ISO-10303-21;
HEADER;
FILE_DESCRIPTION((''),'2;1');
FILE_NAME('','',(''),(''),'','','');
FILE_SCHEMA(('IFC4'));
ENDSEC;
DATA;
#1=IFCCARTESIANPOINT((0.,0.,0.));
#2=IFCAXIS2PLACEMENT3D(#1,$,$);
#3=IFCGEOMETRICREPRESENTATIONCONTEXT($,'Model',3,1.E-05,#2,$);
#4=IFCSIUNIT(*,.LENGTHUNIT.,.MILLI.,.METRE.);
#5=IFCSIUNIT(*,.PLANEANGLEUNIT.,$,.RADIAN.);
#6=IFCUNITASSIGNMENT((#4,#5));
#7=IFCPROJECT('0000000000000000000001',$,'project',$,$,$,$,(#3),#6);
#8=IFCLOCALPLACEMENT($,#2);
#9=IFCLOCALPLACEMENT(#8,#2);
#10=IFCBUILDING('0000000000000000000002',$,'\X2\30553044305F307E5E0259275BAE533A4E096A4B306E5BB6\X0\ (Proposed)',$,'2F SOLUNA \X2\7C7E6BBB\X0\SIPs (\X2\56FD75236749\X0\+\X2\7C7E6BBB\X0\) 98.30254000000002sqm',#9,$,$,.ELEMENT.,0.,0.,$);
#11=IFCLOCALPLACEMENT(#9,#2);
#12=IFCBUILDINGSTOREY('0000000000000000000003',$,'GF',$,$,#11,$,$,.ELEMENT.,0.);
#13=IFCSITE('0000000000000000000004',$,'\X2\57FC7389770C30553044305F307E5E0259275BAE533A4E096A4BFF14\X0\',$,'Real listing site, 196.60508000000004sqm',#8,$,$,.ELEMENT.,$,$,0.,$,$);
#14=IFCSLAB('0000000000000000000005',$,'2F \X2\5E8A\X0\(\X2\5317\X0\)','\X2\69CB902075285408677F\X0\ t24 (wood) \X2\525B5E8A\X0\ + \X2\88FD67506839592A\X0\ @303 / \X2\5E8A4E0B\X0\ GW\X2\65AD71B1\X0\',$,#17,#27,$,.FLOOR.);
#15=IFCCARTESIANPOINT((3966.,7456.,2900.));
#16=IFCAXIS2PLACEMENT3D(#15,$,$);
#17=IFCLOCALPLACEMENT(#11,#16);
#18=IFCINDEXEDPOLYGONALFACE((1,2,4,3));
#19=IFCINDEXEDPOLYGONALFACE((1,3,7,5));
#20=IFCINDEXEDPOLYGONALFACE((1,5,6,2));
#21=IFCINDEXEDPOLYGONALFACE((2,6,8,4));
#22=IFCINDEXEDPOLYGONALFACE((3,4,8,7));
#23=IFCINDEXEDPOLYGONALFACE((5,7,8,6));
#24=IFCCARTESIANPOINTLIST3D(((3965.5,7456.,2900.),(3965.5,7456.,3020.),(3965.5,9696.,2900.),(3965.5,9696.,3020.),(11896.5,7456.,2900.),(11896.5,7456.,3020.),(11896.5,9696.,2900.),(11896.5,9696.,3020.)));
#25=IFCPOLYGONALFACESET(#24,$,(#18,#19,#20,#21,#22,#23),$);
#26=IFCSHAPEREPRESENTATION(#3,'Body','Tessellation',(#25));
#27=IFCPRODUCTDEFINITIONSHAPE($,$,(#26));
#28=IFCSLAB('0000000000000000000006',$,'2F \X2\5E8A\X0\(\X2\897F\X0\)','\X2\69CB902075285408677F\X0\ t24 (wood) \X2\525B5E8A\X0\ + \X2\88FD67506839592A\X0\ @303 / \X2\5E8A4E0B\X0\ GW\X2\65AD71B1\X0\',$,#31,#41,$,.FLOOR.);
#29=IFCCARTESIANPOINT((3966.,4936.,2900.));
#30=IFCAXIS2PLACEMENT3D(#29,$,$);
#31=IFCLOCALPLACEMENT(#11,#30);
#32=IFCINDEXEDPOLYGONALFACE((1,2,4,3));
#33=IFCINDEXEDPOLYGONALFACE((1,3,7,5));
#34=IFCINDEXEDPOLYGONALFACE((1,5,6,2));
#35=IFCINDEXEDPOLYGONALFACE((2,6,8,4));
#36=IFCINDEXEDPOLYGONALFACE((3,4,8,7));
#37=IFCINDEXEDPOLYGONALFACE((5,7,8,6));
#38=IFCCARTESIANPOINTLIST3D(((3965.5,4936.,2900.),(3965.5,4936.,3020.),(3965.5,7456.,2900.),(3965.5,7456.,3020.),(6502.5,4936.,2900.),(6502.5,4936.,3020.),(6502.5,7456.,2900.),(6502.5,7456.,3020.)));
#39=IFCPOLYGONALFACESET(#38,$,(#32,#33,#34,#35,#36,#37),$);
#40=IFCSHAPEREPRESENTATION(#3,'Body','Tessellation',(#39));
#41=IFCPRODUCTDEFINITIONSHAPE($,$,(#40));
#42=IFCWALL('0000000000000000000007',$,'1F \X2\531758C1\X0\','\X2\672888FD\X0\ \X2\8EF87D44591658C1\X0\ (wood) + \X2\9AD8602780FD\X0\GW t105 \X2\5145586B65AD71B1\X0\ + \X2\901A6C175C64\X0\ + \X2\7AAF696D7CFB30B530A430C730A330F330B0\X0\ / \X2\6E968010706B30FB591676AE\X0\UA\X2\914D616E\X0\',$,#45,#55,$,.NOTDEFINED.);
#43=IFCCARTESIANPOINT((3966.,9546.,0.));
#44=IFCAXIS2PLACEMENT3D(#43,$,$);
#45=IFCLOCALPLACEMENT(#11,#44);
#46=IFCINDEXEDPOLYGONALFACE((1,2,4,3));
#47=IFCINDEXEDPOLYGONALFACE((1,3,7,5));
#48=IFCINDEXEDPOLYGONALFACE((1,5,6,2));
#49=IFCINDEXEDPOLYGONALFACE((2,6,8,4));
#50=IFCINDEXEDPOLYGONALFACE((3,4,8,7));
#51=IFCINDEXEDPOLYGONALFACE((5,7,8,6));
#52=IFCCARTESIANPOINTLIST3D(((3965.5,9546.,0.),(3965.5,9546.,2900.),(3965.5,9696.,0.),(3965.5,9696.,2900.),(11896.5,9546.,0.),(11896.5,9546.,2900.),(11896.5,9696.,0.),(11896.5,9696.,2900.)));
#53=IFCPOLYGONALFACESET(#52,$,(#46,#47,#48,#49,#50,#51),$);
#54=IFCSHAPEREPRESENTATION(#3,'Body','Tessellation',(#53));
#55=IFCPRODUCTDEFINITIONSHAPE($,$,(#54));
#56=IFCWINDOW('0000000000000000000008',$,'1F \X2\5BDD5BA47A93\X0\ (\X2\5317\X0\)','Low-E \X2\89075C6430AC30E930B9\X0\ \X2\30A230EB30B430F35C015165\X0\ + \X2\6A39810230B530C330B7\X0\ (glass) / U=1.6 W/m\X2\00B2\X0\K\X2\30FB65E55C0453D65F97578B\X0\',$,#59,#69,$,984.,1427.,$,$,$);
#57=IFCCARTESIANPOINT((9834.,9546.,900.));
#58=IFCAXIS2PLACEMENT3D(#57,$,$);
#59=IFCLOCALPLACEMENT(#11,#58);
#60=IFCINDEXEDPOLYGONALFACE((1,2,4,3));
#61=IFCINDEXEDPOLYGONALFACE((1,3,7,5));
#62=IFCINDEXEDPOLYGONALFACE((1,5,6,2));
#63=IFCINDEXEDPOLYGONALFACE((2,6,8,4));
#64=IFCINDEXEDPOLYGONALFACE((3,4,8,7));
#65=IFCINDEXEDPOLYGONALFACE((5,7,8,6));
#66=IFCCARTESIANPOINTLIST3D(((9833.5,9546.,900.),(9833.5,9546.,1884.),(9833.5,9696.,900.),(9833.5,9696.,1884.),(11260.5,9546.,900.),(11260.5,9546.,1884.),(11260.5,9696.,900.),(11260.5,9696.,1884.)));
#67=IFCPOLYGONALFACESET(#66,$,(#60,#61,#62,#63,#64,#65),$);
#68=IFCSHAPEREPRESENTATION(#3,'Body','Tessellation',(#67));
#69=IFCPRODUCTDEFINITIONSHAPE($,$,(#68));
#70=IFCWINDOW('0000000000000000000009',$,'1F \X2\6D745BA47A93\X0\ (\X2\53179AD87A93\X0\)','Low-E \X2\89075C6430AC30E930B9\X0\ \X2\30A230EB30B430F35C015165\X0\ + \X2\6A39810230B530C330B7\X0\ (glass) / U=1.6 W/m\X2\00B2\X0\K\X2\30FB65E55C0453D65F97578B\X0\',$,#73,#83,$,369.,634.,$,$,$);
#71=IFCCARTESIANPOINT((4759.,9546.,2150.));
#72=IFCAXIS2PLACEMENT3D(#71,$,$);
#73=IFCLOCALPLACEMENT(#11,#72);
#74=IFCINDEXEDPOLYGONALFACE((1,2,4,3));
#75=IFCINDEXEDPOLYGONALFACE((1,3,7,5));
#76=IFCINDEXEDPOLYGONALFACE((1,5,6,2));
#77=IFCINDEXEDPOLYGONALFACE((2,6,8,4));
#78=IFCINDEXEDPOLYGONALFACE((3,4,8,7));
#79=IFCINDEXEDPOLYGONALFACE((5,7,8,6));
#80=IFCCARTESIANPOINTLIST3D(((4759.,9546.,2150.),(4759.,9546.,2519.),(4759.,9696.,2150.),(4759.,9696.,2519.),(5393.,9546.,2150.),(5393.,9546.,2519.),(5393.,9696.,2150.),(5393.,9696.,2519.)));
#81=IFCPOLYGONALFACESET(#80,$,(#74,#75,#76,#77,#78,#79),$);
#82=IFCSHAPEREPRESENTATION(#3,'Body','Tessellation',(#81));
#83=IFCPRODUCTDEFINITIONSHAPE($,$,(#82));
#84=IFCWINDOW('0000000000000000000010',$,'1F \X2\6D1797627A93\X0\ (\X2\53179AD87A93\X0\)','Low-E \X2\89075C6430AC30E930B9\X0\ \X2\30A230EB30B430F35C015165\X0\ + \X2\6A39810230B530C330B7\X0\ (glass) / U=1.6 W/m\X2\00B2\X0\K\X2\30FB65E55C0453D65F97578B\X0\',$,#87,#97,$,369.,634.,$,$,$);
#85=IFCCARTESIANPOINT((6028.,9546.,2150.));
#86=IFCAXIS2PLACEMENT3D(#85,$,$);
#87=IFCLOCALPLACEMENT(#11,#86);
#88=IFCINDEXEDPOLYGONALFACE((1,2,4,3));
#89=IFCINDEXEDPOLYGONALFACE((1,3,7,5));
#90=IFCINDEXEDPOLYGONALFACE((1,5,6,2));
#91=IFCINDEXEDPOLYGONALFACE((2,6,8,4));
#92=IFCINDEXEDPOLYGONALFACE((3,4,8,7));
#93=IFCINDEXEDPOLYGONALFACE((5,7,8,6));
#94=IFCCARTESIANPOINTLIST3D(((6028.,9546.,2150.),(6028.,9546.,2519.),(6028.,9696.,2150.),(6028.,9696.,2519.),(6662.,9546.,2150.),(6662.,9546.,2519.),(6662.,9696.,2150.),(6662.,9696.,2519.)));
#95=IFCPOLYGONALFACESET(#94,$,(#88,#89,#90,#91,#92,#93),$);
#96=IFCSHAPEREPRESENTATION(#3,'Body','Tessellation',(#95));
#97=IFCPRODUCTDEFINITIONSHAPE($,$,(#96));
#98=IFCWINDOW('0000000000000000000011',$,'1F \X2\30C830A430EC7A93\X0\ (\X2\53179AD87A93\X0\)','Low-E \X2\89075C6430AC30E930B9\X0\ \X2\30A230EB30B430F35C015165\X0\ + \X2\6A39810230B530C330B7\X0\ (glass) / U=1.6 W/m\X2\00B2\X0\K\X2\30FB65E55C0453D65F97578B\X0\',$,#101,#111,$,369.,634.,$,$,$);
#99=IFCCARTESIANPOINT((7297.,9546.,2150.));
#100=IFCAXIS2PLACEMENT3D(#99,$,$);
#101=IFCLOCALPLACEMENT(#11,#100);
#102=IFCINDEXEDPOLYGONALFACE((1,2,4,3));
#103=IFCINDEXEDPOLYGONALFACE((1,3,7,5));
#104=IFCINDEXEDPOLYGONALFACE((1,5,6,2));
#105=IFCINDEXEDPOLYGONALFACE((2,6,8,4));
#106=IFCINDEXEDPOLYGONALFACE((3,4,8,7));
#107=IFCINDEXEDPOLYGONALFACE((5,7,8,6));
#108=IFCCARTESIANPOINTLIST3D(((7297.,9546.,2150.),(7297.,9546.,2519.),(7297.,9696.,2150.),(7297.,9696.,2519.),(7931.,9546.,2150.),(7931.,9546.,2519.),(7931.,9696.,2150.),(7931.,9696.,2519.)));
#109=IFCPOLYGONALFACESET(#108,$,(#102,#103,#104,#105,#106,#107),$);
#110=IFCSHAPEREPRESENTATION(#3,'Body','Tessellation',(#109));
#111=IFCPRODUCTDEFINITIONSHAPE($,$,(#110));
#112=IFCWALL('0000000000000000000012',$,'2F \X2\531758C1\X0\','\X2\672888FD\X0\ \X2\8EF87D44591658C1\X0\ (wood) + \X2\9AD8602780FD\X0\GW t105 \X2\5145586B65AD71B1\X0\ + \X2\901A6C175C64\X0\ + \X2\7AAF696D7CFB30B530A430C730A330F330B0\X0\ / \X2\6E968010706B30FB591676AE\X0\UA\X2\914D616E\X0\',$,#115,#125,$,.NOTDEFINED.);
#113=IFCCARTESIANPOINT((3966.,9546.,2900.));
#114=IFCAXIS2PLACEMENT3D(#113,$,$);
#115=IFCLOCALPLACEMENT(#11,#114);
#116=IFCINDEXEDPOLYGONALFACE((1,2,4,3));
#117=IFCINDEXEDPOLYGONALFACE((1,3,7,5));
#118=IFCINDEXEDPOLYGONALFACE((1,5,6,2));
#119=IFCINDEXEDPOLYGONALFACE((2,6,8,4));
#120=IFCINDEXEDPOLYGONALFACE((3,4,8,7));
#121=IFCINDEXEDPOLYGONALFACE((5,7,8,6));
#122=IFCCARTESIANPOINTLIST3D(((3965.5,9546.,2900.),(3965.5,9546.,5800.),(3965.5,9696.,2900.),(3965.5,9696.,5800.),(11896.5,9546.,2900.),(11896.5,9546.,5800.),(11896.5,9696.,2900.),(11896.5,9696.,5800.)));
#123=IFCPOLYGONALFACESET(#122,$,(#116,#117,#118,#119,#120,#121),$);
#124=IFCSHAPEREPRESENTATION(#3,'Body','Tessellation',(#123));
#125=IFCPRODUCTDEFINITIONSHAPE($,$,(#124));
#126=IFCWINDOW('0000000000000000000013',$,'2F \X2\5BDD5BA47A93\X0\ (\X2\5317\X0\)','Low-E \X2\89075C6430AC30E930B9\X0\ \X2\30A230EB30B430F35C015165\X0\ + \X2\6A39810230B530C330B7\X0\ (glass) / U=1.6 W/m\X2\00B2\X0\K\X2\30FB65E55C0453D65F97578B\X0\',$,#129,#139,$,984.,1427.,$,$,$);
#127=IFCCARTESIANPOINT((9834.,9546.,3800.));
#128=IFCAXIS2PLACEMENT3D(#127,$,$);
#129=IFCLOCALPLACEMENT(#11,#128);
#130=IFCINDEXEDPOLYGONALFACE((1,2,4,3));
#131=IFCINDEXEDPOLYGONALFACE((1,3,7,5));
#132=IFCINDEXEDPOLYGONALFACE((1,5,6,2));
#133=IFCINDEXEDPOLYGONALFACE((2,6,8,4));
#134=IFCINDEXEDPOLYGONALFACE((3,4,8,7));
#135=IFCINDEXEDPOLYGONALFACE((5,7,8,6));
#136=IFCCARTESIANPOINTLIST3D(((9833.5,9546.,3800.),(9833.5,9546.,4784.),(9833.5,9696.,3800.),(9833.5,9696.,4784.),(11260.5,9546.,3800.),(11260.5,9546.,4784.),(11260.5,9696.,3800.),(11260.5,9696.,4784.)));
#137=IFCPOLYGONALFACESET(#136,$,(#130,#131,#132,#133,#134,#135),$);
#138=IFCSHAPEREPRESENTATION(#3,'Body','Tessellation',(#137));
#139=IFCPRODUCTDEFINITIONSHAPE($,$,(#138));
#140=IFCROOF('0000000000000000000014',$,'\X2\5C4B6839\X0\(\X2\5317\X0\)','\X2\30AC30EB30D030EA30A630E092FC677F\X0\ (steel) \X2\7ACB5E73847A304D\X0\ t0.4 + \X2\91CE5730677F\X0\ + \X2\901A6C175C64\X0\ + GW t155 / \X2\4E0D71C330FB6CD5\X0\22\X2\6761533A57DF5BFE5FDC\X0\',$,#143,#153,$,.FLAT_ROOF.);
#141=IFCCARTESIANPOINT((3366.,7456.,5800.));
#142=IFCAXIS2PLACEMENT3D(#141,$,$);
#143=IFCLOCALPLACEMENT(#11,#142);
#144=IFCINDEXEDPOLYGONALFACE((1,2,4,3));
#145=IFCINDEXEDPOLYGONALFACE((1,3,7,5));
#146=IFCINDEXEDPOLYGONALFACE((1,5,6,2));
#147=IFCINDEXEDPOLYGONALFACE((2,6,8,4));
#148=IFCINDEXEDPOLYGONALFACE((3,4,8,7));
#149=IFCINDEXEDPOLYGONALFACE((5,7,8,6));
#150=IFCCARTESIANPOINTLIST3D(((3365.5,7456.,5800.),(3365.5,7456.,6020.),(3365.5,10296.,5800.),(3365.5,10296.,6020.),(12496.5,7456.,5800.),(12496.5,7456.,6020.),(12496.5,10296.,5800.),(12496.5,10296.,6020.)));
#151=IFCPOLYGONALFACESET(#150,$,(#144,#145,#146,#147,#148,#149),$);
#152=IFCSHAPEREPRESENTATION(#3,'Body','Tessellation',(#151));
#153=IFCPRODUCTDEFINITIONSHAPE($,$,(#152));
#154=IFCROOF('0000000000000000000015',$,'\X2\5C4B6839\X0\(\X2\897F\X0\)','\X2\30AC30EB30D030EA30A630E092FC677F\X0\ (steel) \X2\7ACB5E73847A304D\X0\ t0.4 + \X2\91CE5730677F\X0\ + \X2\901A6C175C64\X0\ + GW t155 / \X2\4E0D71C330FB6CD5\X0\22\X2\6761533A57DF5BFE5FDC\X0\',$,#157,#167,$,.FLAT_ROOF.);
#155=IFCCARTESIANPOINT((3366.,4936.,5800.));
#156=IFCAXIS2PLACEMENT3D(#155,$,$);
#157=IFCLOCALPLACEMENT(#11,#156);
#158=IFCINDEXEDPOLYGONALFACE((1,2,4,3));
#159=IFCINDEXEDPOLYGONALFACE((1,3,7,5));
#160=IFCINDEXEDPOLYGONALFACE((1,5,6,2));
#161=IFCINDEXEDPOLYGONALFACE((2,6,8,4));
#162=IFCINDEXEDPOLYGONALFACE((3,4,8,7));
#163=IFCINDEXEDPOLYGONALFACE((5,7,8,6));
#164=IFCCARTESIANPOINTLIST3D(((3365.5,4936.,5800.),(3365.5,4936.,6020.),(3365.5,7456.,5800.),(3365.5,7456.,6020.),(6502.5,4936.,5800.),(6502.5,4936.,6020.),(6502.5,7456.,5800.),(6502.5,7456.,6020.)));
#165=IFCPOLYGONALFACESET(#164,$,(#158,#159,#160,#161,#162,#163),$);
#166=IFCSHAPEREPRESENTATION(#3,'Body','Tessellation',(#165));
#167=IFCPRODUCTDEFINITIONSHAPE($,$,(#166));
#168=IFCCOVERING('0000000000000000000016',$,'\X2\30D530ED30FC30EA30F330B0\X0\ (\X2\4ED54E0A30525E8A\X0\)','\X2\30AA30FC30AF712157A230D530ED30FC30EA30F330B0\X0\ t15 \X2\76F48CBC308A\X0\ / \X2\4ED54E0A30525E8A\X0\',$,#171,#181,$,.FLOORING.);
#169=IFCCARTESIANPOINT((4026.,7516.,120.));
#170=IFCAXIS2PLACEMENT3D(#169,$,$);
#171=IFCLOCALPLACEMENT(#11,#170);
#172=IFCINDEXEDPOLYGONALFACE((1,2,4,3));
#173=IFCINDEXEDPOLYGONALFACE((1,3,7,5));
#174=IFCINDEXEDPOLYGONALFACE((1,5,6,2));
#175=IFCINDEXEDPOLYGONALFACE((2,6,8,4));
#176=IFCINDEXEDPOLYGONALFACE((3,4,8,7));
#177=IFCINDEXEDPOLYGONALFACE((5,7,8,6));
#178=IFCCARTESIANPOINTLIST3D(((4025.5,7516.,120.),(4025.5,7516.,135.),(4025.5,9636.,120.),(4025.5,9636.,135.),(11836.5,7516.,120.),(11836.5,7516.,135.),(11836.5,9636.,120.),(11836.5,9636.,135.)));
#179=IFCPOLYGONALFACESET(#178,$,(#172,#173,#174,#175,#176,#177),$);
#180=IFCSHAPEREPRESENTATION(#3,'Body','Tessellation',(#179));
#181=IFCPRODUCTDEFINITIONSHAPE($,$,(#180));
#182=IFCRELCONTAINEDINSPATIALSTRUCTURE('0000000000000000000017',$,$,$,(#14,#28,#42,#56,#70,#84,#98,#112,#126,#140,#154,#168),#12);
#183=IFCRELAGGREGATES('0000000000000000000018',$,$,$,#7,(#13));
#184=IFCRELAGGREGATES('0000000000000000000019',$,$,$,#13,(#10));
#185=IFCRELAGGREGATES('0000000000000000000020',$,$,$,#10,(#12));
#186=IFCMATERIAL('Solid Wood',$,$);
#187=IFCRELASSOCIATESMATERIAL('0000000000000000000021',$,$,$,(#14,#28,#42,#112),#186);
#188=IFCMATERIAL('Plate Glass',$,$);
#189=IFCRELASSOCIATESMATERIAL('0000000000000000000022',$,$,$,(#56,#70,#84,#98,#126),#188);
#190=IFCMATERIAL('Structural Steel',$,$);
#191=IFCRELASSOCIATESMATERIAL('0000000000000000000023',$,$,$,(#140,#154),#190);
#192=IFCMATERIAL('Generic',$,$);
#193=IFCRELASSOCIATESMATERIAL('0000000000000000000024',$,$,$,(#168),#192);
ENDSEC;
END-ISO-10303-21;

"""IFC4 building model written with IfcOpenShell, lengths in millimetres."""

from ifc_helpers import new_model, si_unit, frame, frame_2d, origin, place, context, project, spatial, rectangle, extrude, material, element, fill, save


model = new_model("IFC4")

# Units and contexts
model_context = context("Model", 3, precision=1e-05, world=origin())
ifc_project = project(units=[si_unit("LENGTHUNIT", "METRE", prefix="MILLI"), si_unit("PLANEANGLEUNIT", "RADIAN")], contexts=[model_context])

# Site, building, storey
site_placement = place(None, origin())
site = spatial("IfcSite", under=ifc_project, at=site_placement, Name="埼玉県さいたま市大宮区三橋４", ObjectType="Real listing site, 196.60508000000004sqm", CompositionType="ELEMENT", RefElevation=0.0)
building_placement = place(site_placement, origin())
building = spatial("IfcBuilding", under=site, at=building_placement, Name="さいたま市大宮区三橋の家 (Proposed)", ObjectType="2F SOLUNA 籾殻SIPs (国産杉+籾殻) 98.30254000000002sqm", CompositionType="ELEMENT", ElevationOfRefHeight=0.0, ElevationOfTerrain=0.0)
storey_placement = place(building_placement, origin())
storey = spatial("IfcBuildingStorey", under=building, at=storey_placement, Name="GF", CompositionType="ELEMENT", Elevation=0.0)

# Slabs
ifc_material_1 = material(Name="Solid Wood")
slab_1_placement = place(storey_placement, frame((3966.0, 7456.0, 2900.0)))
element("IfcSlab", 1, at=slab_1_placement, inside=storey, material=ifc_material_1, Name="2F 床(北)", Description="構造用合板 t24 (wood) 剛床 + 製材根太 @303 / 床下 GW断熱", PredefinedType="FLOOR", context=model_context, shape_type="SweptSolid", body=[
    extrude(rectangle(XDim=7931.0, YDim=2240.0, at=frame_2d((3965.0, 1120.0))), frame((3966.0, 7456.0, 2900.0)), (0.0, 0.0, 1.0), 120.0),
])
slab_2_placement = place(storey_placement, frame((3966.0, 4936.0, 2900.0)))
element("IfcSlab", 2, at=slab_2_placement, inside=storey, material=ifc_material_1, Name="2F 床(西)", Description="構造用合板 t24 (wood) 剛床 + 製材根太 @303 / 床下 GW断熱", PredefinedType="FLOOR", context=model_context, shape_type="SweptSolid", body=[
    extrude(rectangle(XDim=2537.0, YDim=2520.0, at=frame_2d((1268.0, 1260.0))), frame((3966.0, 4936.0, 2900.0)), (0.0, 0.0, 1.0), 120.0),
])

# Wall, openings, windows
wall_1_placement = place(storey_placement, frame((3966.0, 9546.0, 0.0)))
wall_1 = element("IfcWall", 3, at=wall_1_placement, inside=storey, material=ifc_material_1, Name="1F 北壁", Description="木製 軸組外壁 (wood) + 高性能GW t105 充填断熱 + 通気層 + 窯業系サイディング / 準耐火・外皮UA配慮", PredefinedType="NOTDEFINED", context=model_context, shape_type="SweptSolid", body=[
    extrude(rectangle(XDim=7931.0, YDim=150.0, at=frame_2d((3965.0, 75.0))), frame((3966.0, 9546.0, 0.0)), (0.0, 0.0, 1.0), 2900.0),
])
opening_1_placement = place(storey_placement, frame((9834.0, 9546.0, 900.0)))
opening_1 = element("IfcOpeningElement", 4, at=opening_1_placement, cuts=wall_1, PredefinedType="NOTDEFINED", context=model_context, shape_type="SweptSolid", body=[
    extrude(rectangle(XDim=1427.0, YDim=150.0, at=frame_2d((713.0, 75.0))), frame((9834.0, 9546.0, 900.0)), (0.0, 0.0, 1.0), 984.0),
])
opening_2_placement = place(storey_placement, frame((4759.0, 9546.0, 2150.0)))
opening_2 = element("IfcOpeningElement", 5, at=opening_2_placement, cuts=wall_1, PredefinedType="NOTDEFINED", context=model_context, shape_type="SweptSolid", body=[
    extrude(rectangle(XDim=634.0, YDim=150.0, at=frame_2d((317.0, 75.0))), frame((4759.0, 9546.0, 2150.0)), (0.0, 0.0, 1.0), 369.0),
])
opening_3_placement = place(storey_placement, frame((6028.0, 9546.0, 2150.0)))
opening_3 = element("IfcOpeningElement", 6, at=opening_3_placement, cuts=wall_1, PredefinedType="NOTDEFINED", context=model_context, shape_type="SweptSolid", body=[
    extrude(rectangle(XDim=634.0, YDim=150.0, at=frame_2d((317.0, 75.0))), frame((6028.0, 9546.0, 2150.0)), (0.0, 0.0, 1.0), 369.0),
])
opening_4_placement = place(storey_placement, frame((7297.0, 9546.0, 2150.0)))
opening_4 = element("IfcOpeningElement", 7, at=opening_4_placement, cuts=wall_1, PredefinedType="NOTDEFINED", context=model_context, shape_type="SweptSolid", body=[
    extrude(rectangle(XDim=634.0, YDim=150.0, at=frame_2d((317.0, 75.0))), frame((7297.0, 9546.0, 2150.0)), (0.0, 0.0, 1.0), 369.0),
])
ifc_material_2 = material(Name="Plate Glass")
window_1_placement = place(storey_placement, frame((9834.0, 9546.0, 900.0)))
window_1 = element("IfcWindow", 8, at=window_1_placement, inside=storey, material=ifc_material_2, Name="1F 寝室窓 (北)", Description="Low-E 複層ガラス アルゴン封入 + 樹脂サッシ (glass) / U=1.6 W/m²K・日射取得型", OverallHeight=984.0, OverallWidth=1427.0, context=model_context, shape_type="SweptSolid", body=[
    extrude(rectangle(XDim=1427.0, YDim=150.0, at=frame_2d((713.0, 75.0))), frame((9834.0, 9546.0, 900.0)), (0.0, 0.0, 1.0), 984.0),
])
fill(opening_1, window_1)
window_2_placement = place(storey_placement, frame((4759.0, 9546.0, 2150.0)))
window_2 = element("IfcWindow", 9, at=window_2_placement, inside=storey, material=ifc_material_2, Name="1F 浴室窓 (北高窓)", Description="Low-E 複層ガラス アルゴン封入 + 樹脂サッシ (glass) / U=1.6 W/m²K・日射取得型", OverallHeight=369.0, OverallWidth=634.0, context=model_context, shape_type="SweptSolid", body=[
    extrude(rectangle(XDim=634.0, YDim=150.0, at=frame_2d((317.0, 75.0))), frame((4759.0, 9546.0, 2150.0)), (0.0, 0.0, 1.0), 369.0),
])
fill(opening_2, window_2)
window_3_placement = place(storey_placement, frame((6028.0, 9546.0, 2150.0)))
window_3 = element("IfcWindow", 10, at=window_3_placement, inside=storey, material=ifc_material_2, Name="1F 洗面窓 (北高窓)", Description="Low-E 複層ガラス アルゴン封入 + 樹脂サッシ (glass) / U=1.6 W/m²K・日射取得型", OverallHeight=369.0, OverallWidth=634.0, context=model_context, shape_type="SweptSolid", body=[
    extrude(rectangle(XDim=634.0, YDim=150.0, at=frame_2d((317.0, 75.0))), frame((6028.0, 9546.0, 2150.0)), (0.0, 0.0, 1.0), 369.0),
])
fill(opening_3, window_3)
window_4_placement = place(storey_placement, frame((7297.0, 9546.0, 2150.0)))
window_4 = element("IfcWindow", 11, at=window_4_placement, inside=storey, material=ifc_material_2, Name="1F トイレ窓 (北高窓)", Description="Low-E 複層ガラス アルゴン封入 + 樹脂サッシ (glass) / U=1.6 W/m²K・日射取得型", OverallHeight=369.0, OverallWidth=634.0, context=model_context, shape_type="SweptSolid", body=[
    extrude(rectangle(XDim=634.0, YDim=150.0, at=frame_2d((317.0, 75.0))), frame((7297.0, 9546.0, 2150.0)), (0.0, 0.0, 1.0), 369.0),
])
fill(opening_4, window_4)

# Wall, opening, window
wall_2_placement = place(storey_placement, frame((3966.0, 9546.0, 2900.0)))
wall_2 = element("IfcWall", 12, at=wall_2_placement, inside=storey, material=ifc_material_1, Name="2F 北壁", Description="木製 軸組外壁 (wood) + 高性能GW t105 充填断熱 + 通気層 + 窯業系サイディング / 準耐火・外皮UA配慮", PredefinedType="NOTDEFINED", context=model_context, shape_type="SweptSolid", body=[
    extrude(rectangle(XDim=7931.0, YDim=150.0, at=frame_2d((3965.0, 75.0))), frame((3966.0, 9546.0, 2900.0)), (0.0, 0.0, 1.0), 2900.0),
])
opening_5_placement = place(storey_placement, frame((9834.0, 9546.0, 3800.0)))
opening_5 = element("IfcOpeningElement", 13, at=opening_5_placement, cuts=wall_2, PredefinedType="NOTDEFINED", context=model_context, shape_type="SweptSolid", body=[
    extrude(rectangle(XDim=1427.0, YDim=150.0, at=frame_2d((713.0, 75.0))), frame((9834.0, 9546.0, 3800.0)), (0.0, 0.0, 1.0), 984.0),
])
window_5_placement = place(storey_placement, frame((9834.0, 9546.0, 3800.0)))
window_5 = element("IfcWindow", 14, at=window_5_placement, inside=storey, material=ifc_material_2, Name="2F 寝室窓 (北)", Description="Low-E 複層ガラス アルゴン封入 + 樹脂サッシ (glass) / U=1.6 W/m²K・日射取得型", OverallHeight=984.0, OverallWidth=1427.0, context=model_context, shape_type="SweptSolid", body=[
    extrude(rectangle(XDim=1427.0, YDim=150.0, at=frame_2d((713.0, 75.0))), frame((9834.0, 9546.0, 3800.0)), (0.0, 0.0, 1.0), 984.0),
])
fill(opening_5, window_5)

# Roofs
ifc_material_3 = material(Name="Structural Steel")
for number, where, name in (
    (15, (3366.0, 7456.0, 5800.0), "屋根(北)"),
):
    element("IfcRoof", number, at=place(storey_placement, frame(where)), inside=storey, material=ifc_material_3, Name=name, Description="ガルバリウム鋼板 (steel) 立平葺き t0.4 + 野地板 + 通気層 + GW t155 / 不燃・法22条区域対応", PredefinedType="FLAT_ROOF", context=model_context, shape_type="SweptSolid", body=[
        extrude(rectangle(XDim=9131.0, YDim=2840.0, at=frame_2d((4565.0, 1420.0))), frame((3366.0, 7456.0, 5800.0)), (0.0, 0.0, 1.0), 220.0),
    ])
roof_placement = place(storey_placement, frame((3366.0, 4936.0, 5800.0)))
element("IfcRoof", 16, at=roof_placement, inside=storey, material=ifc_material_3, Name="屋根(西)", Description="ガルバリウム鋼板 (steel) 立平葺き t0.4 + 野地板 + 通気層 + GW t155 / 不燃・法22条区域対応", PredefinedType="FLAT_ROOF", context=model_context, shape_type="SweptSolid", body=[
    extrude(rectangle(XDim=3137.0, YDim=2520.0, at=frame_2d((1568.0, 1260.0))), frame((3366.0, 4936.0, 5800.0)), (0.0, 0.0, 1.0), 220.0),
])

# Covering
ifc_material_4 = material(Name="Generic")
covering_1_placement = place(storey_placement, frame((4026.0, 7516.0, 120.0)))
element("IfcCovering", 17, at=covering_1_placement, inside=storey, material=ifc_material_4, Name="フローリング (仕上げ床)", Description="オーク無垢フローリング t15 直貼り / 仕上げ床", PredefinedType="FLOORING", context=model_context, shape_type="SweptSolid", body=[
    extrude(rectangle(XDim=7811.0, YDim=2120.0, at=frame_2d((3905.0, 1060.0))), frame((4026.0, 7516.0, 120.0)), (0.0, 0.0, 1.0), 15.0),
])

save(model, "model.ifc")
